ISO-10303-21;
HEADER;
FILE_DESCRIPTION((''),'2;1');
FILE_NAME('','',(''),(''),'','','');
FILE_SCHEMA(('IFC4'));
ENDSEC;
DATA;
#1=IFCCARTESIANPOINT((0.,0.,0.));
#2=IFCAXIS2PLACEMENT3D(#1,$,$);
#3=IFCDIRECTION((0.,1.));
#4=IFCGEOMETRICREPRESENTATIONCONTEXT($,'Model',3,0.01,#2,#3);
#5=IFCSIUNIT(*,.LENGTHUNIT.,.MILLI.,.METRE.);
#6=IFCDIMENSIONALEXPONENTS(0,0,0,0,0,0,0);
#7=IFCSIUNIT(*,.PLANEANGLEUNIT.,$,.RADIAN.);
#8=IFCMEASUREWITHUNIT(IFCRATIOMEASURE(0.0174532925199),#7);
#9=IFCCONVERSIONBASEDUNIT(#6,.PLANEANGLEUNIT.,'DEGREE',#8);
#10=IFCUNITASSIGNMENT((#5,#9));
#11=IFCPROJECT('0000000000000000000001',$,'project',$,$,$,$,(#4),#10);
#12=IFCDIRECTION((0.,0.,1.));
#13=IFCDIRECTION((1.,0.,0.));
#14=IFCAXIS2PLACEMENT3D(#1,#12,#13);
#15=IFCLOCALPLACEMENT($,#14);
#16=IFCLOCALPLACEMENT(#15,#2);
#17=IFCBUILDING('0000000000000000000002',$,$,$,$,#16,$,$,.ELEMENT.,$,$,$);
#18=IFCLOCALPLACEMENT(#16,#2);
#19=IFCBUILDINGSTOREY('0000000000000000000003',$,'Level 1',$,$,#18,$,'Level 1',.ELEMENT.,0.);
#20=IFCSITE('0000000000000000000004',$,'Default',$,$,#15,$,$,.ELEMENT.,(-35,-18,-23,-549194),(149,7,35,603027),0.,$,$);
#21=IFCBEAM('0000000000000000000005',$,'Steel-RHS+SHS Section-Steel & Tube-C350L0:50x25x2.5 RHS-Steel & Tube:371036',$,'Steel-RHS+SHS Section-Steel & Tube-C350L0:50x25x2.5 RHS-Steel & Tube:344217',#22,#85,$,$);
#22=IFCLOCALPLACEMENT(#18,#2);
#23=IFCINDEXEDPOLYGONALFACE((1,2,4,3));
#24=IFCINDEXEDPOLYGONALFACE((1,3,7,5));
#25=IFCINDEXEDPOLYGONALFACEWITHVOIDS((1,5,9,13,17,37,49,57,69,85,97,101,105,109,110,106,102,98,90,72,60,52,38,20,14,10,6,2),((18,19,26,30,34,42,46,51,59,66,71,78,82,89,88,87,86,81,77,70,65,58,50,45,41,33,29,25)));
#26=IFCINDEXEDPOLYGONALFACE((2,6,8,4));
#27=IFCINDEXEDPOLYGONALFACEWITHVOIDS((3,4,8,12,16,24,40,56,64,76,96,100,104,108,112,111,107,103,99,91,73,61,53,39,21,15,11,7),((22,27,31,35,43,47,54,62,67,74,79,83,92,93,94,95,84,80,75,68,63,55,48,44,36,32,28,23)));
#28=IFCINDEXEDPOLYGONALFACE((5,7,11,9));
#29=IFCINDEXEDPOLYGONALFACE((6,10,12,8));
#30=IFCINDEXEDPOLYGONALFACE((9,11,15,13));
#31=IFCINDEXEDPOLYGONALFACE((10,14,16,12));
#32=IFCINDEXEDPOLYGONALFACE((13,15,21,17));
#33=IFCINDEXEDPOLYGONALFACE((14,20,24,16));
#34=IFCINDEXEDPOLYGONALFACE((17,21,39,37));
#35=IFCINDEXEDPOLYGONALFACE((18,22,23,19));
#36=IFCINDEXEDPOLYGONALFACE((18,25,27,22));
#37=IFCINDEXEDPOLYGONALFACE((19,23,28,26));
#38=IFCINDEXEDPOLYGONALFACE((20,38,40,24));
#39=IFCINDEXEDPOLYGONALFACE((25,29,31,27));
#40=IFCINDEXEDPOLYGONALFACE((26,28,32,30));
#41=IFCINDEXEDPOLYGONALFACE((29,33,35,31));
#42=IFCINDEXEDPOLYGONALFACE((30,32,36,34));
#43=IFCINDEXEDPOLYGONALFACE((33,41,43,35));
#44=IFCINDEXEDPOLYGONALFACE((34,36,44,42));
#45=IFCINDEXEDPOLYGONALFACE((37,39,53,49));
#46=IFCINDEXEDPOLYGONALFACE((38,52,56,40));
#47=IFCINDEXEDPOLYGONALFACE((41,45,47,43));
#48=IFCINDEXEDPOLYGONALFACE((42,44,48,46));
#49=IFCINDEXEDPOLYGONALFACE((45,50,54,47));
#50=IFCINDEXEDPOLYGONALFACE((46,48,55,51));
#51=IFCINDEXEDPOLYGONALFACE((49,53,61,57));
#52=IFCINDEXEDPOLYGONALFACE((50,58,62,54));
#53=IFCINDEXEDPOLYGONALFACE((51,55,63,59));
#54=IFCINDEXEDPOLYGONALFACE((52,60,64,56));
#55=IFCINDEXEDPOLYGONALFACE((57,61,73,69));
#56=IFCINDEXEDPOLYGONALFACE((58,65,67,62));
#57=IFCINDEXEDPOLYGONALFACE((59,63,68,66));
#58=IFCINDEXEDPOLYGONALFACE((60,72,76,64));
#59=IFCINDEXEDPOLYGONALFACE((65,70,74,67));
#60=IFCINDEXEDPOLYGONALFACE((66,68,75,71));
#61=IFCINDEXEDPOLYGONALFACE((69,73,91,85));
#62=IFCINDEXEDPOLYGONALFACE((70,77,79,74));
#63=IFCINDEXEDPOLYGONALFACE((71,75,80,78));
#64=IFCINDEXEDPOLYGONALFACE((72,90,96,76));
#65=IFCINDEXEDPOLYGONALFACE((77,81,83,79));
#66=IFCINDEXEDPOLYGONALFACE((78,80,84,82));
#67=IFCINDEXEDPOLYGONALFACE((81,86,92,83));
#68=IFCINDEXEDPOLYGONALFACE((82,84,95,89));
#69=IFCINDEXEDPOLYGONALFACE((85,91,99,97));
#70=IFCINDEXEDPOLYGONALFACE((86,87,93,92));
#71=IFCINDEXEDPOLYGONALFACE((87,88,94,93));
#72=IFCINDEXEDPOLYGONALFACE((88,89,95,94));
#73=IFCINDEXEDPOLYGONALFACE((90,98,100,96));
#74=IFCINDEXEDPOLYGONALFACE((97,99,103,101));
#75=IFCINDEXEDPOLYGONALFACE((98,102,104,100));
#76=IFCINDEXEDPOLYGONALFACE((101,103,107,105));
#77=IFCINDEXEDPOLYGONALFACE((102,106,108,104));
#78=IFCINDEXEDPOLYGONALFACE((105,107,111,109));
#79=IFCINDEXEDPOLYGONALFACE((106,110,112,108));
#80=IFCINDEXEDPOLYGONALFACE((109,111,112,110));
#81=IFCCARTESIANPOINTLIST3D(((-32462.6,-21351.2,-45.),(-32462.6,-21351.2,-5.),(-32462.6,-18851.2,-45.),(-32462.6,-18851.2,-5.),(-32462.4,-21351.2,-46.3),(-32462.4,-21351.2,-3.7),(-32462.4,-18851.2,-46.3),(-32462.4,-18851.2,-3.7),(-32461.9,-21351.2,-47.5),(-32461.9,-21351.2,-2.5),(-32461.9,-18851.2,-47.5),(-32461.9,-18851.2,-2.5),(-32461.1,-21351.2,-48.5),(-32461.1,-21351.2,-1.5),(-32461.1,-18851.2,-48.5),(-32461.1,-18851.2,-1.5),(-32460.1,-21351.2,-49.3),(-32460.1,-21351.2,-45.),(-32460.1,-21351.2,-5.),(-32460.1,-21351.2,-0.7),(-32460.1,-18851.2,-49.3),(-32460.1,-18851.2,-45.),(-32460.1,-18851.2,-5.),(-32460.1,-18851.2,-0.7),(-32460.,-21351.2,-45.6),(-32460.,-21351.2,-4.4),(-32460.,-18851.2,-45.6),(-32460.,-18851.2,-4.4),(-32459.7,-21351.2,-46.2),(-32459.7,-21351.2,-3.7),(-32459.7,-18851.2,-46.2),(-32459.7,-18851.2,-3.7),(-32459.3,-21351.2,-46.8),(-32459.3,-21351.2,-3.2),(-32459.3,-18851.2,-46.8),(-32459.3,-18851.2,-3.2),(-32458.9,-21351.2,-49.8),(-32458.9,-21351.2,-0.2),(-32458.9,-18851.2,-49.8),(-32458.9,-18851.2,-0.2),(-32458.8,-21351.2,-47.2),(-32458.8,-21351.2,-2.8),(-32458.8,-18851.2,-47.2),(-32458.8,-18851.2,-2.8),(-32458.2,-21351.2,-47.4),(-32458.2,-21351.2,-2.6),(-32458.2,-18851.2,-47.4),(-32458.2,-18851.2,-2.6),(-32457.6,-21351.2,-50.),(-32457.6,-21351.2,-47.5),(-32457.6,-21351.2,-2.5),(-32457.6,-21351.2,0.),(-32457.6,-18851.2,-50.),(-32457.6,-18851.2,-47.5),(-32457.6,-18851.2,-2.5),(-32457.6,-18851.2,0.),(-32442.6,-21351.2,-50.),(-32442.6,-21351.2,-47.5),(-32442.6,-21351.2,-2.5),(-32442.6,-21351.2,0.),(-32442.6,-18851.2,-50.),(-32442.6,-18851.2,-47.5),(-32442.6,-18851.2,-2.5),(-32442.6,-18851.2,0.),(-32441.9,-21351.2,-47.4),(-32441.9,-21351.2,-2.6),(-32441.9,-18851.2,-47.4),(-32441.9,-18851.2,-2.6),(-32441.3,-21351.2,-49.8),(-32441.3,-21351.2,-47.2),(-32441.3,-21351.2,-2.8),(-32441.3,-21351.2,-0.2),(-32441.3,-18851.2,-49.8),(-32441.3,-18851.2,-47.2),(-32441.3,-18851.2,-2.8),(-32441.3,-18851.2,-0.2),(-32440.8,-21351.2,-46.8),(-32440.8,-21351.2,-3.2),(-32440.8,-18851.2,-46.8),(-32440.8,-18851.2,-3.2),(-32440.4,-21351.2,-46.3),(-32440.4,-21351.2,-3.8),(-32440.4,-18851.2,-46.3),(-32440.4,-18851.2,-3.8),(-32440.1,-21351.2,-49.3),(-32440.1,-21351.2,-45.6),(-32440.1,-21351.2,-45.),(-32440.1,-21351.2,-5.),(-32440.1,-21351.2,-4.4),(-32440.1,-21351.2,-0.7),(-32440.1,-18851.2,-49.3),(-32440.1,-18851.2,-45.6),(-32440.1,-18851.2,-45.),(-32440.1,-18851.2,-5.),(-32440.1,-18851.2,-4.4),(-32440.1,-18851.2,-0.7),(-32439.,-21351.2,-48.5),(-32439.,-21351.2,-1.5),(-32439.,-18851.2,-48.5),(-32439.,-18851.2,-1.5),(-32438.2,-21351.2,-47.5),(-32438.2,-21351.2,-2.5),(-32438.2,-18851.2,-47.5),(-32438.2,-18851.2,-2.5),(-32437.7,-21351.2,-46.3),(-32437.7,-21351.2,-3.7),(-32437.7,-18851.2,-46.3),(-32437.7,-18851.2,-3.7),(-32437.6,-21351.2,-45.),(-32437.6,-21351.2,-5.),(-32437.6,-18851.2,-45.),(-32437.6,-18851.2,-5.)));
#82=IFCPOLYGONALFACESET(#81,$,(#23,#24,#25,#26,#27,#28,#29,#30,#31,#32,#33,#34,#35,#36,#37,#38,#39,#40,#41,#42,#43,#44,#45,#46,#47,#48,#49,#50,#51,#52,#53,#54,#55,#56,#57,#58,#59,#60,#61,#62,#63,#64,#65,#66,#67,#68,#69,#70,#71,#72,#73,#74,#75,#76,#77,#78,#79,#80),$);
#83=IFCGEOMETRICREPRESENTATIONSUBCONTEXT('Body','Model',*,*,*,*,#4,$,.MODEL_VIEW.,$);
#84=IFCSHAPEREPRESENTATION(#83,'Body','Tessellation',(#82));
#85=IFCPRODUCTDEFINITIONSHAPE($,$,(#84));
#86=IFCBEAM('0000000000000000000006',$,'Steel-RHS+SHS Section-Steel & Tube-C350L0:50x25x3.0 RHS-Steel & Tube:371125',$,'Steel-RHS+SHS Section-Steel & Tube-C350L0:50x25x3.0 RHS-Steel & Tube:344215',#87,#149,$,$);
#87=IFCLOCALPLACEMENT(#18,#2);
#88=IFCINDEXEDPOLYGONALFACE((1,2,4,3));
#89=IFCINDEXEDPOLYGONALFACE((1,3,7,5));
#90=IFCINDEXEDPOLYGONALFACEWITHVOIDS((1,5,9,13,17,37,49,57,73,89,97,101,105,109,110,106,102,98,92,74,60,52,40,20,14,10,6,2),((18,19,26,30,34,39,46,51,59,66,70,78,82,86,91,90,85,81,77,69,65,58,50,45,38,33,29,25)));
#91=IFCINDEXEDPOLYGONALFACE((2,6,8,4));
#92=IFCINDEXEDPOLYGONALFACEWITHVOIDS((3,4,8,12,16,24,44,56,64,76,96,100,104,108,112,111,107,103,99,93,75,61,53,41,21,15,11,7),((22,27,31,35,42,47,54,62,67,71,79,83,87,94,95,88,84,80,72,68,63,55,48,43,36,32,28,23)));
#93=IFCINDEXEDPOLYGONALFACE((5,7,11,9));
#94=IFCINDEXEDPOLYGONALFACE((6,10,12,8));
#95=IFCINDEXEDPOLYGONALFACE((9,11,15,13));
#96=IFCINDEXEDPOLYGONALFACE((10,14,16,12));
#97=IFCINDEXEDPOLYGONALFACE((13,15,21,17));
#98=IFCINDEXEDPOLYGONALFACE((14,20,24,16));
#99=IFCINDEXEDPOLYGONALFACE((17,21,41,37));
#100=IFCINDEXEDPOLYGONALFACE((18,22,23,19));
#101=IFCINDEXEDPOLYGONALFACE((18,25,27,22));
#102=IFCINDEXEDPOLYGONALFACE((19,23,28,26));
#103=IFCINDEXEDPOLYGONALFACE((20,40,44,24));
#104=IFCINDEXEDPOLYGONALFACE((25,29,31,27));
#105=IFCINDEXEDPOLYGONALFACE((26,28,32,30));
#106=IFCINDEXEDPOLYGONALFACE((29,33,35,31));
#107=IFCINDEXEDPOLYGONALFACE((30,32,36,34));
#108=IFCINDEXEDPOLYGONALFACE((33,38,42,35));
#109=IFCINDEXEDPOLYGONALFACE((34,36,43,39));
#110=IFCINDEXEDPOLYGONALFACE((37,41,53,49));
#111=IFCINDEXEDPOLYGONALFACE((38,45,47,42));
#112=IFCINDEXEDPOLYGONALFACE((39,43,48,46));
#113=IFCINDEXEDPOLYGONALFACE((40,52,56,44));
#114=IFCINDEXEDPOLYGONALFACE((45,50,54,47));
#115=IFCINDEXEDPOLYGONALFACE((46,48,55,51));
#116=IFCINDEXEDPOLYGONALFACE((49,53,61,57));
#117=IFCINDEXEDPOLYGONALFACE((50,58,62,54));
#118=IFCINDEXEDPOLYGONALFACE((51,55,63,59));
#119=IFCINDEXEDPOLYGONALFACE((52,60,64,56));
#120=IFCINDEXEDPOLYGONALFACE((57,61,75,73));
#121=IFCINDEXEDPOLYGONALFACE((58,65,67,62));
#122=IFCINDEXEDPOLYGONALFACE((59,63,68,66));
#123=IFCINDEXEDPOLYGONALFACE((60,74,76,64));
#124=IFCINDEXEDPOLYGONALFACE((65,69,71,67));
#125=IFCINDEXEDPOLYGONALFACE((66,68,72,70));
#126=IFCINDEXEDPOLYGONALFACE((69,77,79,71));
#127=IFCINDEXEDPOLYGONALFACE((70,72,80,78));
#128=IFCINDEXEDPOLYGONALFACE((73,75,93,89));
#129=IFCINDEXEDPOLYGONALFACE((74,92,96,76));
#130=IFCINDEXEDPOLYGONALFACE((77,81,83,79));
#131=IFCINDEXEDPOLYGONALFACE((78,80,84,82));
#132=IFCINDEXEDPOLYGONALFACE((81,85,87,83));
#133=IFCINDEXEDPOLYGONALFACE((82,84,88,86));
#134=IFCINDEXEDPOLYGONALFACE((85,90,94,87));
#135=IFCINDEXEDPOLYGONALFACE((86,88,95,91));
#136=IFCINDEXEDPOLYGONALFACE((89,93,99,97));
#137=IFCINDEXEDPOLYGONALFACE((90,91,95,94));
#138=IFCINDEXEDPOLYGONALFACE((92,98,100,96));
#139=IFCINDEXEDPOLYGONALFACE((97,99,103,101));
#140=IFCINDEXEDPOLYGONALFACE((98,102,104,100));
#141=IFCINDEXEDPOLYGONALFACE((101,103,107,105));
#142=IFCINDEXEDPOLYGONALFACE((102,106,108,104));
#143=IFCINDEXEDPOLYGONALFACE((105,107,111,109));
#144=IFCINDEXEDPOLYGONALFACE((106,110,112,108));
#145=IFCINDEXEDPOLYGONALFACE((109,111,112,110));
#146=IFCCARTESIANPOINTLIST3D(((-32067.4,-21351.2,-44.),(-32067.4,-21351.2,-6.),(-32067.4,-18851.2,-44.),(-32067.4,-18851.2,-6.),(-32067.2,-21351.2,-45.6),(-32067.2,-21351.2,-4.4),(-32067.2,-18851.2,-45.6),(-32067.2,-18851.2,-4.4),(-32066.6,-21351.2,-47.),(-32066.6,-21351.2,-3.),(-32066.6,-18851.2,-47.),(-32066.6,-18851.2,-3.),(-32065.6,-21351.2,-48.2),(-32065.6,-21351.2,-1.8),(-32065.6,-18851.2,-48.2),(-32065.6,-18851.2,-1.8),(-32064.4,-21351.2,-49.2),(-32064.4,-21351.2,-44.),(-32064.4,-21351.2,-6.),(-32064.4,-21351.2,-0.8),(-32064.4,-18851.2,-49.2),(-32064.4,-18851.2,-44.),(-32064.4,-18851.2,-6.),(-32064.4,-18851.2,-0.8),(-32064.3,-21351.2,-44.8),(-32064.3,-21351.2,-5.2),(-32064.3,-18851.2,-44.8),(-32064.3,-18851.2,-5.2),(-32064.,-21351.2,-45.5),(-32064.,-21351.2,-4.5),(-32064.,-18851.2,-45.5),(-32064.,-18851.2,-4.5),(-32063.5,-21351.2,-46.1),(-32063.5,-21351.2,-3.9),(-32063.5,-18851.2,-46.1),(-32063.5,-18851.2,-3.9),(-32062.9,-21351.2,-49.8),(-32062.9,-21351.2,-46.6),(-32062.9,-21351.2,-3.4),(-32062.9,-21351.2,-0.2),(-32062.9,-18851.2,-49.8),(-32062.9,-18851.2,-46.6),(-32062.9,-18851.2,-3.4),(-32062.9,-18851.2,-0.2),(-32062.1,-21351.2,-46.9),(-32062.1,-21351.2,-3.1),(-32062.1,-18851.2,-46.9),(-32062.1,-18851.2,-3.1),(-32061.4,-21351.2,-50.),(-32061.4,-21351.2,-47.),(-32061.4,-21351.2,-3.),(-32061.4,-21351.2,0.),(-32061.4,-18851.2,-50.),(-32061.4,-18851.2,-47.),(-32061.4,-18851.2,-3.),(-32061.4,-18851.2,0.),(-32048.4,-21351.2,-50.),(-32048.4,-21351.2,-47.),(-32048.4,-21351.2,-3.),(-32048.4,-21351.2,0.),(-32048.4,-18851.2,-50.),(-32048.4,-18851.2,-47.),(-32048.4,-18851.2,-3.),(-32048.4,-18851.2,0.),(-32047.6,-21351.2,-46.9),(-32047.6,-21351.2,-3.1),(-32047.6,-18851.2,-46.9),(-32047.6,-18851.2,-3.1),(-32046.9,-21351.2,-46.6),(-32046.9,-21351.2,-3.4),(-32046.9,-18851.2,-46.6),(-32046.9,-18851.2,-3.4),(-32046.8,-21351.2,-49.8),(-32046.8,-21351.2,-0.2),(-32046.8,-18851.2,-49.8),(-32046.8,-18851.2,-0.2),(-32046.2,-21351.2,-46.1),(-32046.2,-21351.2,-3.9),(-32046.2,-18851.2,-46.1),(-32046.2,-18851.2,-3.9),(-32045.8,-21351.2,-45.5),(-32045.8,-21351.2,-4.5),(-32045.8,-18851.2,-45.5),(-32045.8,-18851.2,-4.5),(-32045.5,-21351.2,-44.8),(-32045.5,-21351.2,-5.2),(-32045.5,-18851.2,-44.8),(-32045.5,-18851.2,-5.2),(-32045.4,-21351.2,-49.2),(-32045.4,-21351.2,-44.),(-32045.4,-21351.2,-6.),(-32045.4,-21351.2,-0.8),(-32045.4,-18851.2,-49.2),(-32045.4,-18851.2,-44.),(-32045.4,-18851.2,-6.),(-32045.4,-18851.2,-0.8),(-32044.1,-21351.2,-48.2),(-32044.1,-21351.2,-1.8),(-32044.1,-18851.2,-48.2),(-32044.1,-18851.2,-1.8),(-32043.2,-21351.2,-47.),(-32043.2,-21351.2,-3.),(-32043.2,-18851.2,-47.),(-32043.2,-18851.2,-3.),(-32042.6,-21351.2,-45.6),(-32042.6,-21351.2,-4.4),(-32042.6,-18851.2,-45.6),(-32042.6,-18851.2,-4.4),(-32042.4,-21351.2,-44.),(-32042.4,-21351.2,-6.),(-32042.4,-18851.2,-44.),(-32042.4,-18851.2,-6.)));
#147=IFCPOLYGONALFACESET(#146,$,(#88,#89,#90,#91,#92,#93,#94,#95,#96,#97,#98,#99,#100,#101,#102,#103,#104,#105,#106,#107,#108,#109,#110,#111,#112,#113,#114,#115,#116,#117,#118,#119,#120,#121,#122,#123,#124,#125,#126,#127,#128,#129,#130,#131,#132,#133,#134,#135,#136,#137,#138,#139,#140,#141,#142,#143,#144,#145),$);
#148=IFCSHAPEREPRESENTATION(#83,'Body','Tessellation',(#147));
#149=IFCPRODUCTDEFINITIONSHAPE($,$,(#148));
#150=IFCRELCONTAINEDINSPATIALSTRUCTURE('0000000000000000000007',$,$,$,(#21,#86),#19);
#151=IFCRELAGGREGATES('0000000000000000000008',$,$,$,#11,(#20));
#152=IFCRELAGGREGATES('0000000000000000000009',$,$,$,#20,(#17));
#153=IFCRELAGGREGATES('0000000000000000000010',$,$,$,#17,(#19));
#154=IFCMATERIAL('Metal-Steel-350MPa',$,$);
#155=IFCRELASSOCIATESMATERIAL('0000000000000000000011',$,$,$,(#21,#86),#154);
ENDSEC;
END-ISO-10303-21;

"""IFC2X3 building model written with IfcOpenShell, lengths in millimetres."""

from ifc_helpers import new_model, entity, si_unit, converted_unit, direction, frame, frame_2d, origin, origin_with_axes, place, context, subcontext, project, spatial, polyline, circle_curve, parameter, trimmed, segment, composite_curve, outline, extrude, material, element, save


model = new_model("IFC2X3")

# Units and contexts
model_context = context("Model", 3, precision=0.01, world=origin(), true_north=direction((0.0, 1.0)))
body_context = subcontext(model_context, "Body", "Model", "MODEL_VIEW")
ifc_project = project(units=[si_unit("LENGTHUNIT", "METRE", prefix="MILLI"), converted_unit("PLANEANGLEUNIT", "DEGREE", entity("IfcRatioMeasure", 0.0174532925199), si_unit("PLANEANGLEUNIT", "RADIAN"), dimensions=[0, 0, 0, 0, 0, 0, 0])], contexts=[model_context])

# Site, building, storey
site_placement = place(None, origin_with_axes())
site = spatial("IfcSite", under=ifc_project, at=site_placement, Name="Default", CompositionType="ELEMENT", RefLatitude=(-35, -18, -23, -549194), RefLongitude=(149, 7, 35, 603027), RefElevation=0.0)
building_placement = place(site_placement, origin())
building = spatial("IfcBuilding", under=site, at=building_placement, CompositionType="ELEMENT")
storey_placement = place(building_placement, origin())
storey = spatial("IfcBuildingStorey", under=building, at=storey_placement, Name="Level 1", LongName="Level 1", CompositionType="ELEMENT", Elevation=0.0)

# Beams
ifc_material = material(Name="Metal-Steel-350MPa")
beam_1_placement = place(storey_placement, frame((-32450.1, -18851.2, 0.0), z_axis=(0.0, 0.0, 1.0), x_axis=(0.0, -1.0, 0.0)))
element("IfcBeam", 1, at=beam_1_placement, inside=storey, material=ifc_material, Name="Steel-RHS+SHS Section-Steel & Tube-C350L0:50x25x2.5 RHS-Steel & Tube:371036", ObjectType="Steel-RHS+SHS Section-Steel & Tube-C350L0:50x25x2.5 RHS-Steel & Tube:344217", context=body_context, shape_type="SweptSolid", body=[
    extrude(outline(composite_curve([segment(trimmed(circle_curve(frame_2d((-7.5, -20.0), x_axis=(1.0, 0.0)), 5.0), [parameter(180.0)], [parameter(270.0)], True, "PARAMETER"), True, "CONTINUOUS"), segment(polyline([(-7.5, -25.0), (7.5, -25.0)]), True, "CONTINUOUS"), segment(trimmed(circle_curve(frame_2d((7.5, -20.0), x_axis=(1.0, 0.0)), 5.0), [parameter(270.0)], [parameter(0.0)], True, "PARAMETER"), True, "CONTINUOUS"), segment(polyline([(12.5, -20.0), (12.5, 20.0)]), True, "CONTINUOUS"), segment(trimmed(circle_curve(frame_2d((7.5, 20.0), x_axis=(1.0, 0.0)), 5.0), [parameter(0.0)], [parameter(90.0)], True, "PARAMETER"), True, "CONTINUOUS"), segment(polyline([(7.5, 25.0), (-7.5, 25.0)]), True, "CONTINUOUS"), segment(trimmed(circle_curve(frame_2d((-7.5, 20.0), x_axis=(1.0, 0.0)), 5.0), [parameter(90.0)], [parameter(180.0)], True, "PARAMETER"), True, "CONTINUOUS"), segment(polyline([(-12.5, 20.0), (-12.5, -20.0)]), True, "CONTINUOUS")], self_intersect=False), holes=[composite_curve([segment(polyline([(7.5, -22.5), (-7.5, -22.5)]), True, "CONTINUOUS"), segment(trimmed(circle_curve(frame_2d((-7.5, -20.0), x_axis=(1.0, 0.0)), 2.5), [parameter(180.0)], [parameter(270.0)], True, "PARAMETER"), False, "CONTINUOUS"), segment(polyline([(-10.0, -20.0), (-10.0, 20.0)]), True, "CONTINUOUS"), segment(trimmed(circle_curve(frame_2d((-7.5, 20.0), x_axis=(1.0, 0.0)), 2.5), [parameter(90.0)], [parameter(180.0)], True, "PARAMETER"), False, "CONTINUOUS"), segment(polyline([(-7.5, 22.5), (7.5, 22.5)]), True, "CONTINUOUS"), segment(trimmed(circle_curve(frame_2d((7.5, 20.0), x_axis=(1.0, 0.0)), 2.5), [parameter(360.0)], [parameter(90.0)], True, "PARAMETER"), False, "CONTINUOUS"), segment(polyline([(10.0, 20.0), (10.0, -20.0)]), True, "CONTINUOUS"), segment(trimmed(circle_curve(frame_2d((7.5, -20.0), x_axis=(1.0, 0.0)), 2.5), [parameter(270.0)], [parameter(0.0)], True, "PARAMETER"), False, "CONTINUOUS")], self_intersect=False)]), frame((0.0, 0.0, -25.0), z_axis=(1.0, 0.0, 0.0), x_axis=(0.0, -1.0, 0.0)), (0.0, 0.0, 1.0), 2500.0),
])
beam_2_placement = place(storey_placement, frame((-32054.9, -18851.2, 0.0), z_axis=(0.0, 0.0, 1.0), x_axis=(0.0, -1.0, 0.0)))
element("IfcBeam", 2, at=beam_2_placement, inside=storey, material=ifc_material, Name="Steel-RHS+SHS Section-Steel & Tube-C350L0:50x25x3.0 RHS-Steel & Tube:371125", ObjectType="Steel-RHS+SHS Section-Steel & Tube-C350L0:50x25x3.0 RHS-Steel & Tube:344215", context=body_context, shape_type="SweptSolid", body=[
    extrude(outline(composite_curve([segment(trimmed(circle_curve(frame_2d((-6.5, -19.0), x_axis=(1.0, 0.0)), 6.0), [parameter(180.0)], [parameter(270.0)], True, "PARAMETER"), True, "CONTINUOUS"), segment(polyline([(-6.5, -25.0), (6.5, -25.0)]), True, "CONTINUOUS"), segment(trimmed(circle_curve(frame_2d((6.5, -19.0), x_axis=(1.0, 0.0)), 6.0), [parameter(270.0)], [parameter(0.0)], True, "PARAMETER"), True, "CONTINUOUS"), segment(polyline([(12.5, -19.0), (12.5, 19.0)]), True, "CONTINUOUS"), segment(trimmed(circle_curve(frame_2d((6.5, 19.0), x_axis=(1.0, 0.0)), 6.0), [parameter(0.0)], [parameter(90.0)], True, "PARAMETER"), True, "CONTINUOUS"), segment(polyline([(6.5, 25.0), (-6.5, 25.0)]), True, "CONTINUOUS"), segment(trimmed(circle_curve(frame_2d((-6.5, 19.0), x_axis=(1.0, 0.0)), 6.0), [parameter(90.0)], [parameter(180.0)], True, "PARAMETER"), True, "CONTINUOUS"), segment(polyline([(-12.5, 19.0), (-12.5, -19.0)]), True, "CONTINUOUS")], self_intersect=False), holes=[composite_curve([segment(polyline([(6.5, -22.0), (-6.5, -22.0)]), True, "CONTINUOUS"), segment(trimmed(circle_curve(frame_2d((-6.5, -19.0), x_axis=(1.0, 0.0)), 3.0), [parameter(180.0)], [parameter(270.0)], True, "PARAMETER"), False, "CONTINUOUS"), segment(polyline([(-9.5, -19.0), (-9.5, 19.0)]), True, "CONTINUOUS"), segment(trimmed(circle_curve(frame_2d((-6.5, 19.0), x_axis=(1.0, 0.0)), 3.0), [parameter(90.0)], [parameter(180.0)], True, "PARAMETER"), False, "CONTINUOUS"), segment(polyline([(-6.5, 22.0), (6.5, 22.0)]), True, "CONTINUOUS"), segment(trimmed(circle_curve(frame_2d((6.5, 19.0), x_axis=(1.0, 0.0)), 3.0), [parameter(360.0)], [parameter(90.0)], True, "PARAMETER"), False, "CONTINUOUS"), segment(polyline([(9.5, 19.0), (9.5, -19.0)]), True, "CONTINUOUS"), segment(trimmed(circle_curve(frame_2d((6.5, -19.0), x_axis=(1.0, 0.0)), 3.0), [parameter(270.0)], [parameter(360.0)], True, "PARAMETER"), False, "CONTINUOUS")], self_intersect=False)]), frame((0.0, 0.0, -25.0), z_axis=(1.0, 0.0, 0.0), x_axis=(0.0, -1.0, 0.0)), (0.0, 0.0, 1.0), 2500.0),
])

save(model, "model.ifc")
